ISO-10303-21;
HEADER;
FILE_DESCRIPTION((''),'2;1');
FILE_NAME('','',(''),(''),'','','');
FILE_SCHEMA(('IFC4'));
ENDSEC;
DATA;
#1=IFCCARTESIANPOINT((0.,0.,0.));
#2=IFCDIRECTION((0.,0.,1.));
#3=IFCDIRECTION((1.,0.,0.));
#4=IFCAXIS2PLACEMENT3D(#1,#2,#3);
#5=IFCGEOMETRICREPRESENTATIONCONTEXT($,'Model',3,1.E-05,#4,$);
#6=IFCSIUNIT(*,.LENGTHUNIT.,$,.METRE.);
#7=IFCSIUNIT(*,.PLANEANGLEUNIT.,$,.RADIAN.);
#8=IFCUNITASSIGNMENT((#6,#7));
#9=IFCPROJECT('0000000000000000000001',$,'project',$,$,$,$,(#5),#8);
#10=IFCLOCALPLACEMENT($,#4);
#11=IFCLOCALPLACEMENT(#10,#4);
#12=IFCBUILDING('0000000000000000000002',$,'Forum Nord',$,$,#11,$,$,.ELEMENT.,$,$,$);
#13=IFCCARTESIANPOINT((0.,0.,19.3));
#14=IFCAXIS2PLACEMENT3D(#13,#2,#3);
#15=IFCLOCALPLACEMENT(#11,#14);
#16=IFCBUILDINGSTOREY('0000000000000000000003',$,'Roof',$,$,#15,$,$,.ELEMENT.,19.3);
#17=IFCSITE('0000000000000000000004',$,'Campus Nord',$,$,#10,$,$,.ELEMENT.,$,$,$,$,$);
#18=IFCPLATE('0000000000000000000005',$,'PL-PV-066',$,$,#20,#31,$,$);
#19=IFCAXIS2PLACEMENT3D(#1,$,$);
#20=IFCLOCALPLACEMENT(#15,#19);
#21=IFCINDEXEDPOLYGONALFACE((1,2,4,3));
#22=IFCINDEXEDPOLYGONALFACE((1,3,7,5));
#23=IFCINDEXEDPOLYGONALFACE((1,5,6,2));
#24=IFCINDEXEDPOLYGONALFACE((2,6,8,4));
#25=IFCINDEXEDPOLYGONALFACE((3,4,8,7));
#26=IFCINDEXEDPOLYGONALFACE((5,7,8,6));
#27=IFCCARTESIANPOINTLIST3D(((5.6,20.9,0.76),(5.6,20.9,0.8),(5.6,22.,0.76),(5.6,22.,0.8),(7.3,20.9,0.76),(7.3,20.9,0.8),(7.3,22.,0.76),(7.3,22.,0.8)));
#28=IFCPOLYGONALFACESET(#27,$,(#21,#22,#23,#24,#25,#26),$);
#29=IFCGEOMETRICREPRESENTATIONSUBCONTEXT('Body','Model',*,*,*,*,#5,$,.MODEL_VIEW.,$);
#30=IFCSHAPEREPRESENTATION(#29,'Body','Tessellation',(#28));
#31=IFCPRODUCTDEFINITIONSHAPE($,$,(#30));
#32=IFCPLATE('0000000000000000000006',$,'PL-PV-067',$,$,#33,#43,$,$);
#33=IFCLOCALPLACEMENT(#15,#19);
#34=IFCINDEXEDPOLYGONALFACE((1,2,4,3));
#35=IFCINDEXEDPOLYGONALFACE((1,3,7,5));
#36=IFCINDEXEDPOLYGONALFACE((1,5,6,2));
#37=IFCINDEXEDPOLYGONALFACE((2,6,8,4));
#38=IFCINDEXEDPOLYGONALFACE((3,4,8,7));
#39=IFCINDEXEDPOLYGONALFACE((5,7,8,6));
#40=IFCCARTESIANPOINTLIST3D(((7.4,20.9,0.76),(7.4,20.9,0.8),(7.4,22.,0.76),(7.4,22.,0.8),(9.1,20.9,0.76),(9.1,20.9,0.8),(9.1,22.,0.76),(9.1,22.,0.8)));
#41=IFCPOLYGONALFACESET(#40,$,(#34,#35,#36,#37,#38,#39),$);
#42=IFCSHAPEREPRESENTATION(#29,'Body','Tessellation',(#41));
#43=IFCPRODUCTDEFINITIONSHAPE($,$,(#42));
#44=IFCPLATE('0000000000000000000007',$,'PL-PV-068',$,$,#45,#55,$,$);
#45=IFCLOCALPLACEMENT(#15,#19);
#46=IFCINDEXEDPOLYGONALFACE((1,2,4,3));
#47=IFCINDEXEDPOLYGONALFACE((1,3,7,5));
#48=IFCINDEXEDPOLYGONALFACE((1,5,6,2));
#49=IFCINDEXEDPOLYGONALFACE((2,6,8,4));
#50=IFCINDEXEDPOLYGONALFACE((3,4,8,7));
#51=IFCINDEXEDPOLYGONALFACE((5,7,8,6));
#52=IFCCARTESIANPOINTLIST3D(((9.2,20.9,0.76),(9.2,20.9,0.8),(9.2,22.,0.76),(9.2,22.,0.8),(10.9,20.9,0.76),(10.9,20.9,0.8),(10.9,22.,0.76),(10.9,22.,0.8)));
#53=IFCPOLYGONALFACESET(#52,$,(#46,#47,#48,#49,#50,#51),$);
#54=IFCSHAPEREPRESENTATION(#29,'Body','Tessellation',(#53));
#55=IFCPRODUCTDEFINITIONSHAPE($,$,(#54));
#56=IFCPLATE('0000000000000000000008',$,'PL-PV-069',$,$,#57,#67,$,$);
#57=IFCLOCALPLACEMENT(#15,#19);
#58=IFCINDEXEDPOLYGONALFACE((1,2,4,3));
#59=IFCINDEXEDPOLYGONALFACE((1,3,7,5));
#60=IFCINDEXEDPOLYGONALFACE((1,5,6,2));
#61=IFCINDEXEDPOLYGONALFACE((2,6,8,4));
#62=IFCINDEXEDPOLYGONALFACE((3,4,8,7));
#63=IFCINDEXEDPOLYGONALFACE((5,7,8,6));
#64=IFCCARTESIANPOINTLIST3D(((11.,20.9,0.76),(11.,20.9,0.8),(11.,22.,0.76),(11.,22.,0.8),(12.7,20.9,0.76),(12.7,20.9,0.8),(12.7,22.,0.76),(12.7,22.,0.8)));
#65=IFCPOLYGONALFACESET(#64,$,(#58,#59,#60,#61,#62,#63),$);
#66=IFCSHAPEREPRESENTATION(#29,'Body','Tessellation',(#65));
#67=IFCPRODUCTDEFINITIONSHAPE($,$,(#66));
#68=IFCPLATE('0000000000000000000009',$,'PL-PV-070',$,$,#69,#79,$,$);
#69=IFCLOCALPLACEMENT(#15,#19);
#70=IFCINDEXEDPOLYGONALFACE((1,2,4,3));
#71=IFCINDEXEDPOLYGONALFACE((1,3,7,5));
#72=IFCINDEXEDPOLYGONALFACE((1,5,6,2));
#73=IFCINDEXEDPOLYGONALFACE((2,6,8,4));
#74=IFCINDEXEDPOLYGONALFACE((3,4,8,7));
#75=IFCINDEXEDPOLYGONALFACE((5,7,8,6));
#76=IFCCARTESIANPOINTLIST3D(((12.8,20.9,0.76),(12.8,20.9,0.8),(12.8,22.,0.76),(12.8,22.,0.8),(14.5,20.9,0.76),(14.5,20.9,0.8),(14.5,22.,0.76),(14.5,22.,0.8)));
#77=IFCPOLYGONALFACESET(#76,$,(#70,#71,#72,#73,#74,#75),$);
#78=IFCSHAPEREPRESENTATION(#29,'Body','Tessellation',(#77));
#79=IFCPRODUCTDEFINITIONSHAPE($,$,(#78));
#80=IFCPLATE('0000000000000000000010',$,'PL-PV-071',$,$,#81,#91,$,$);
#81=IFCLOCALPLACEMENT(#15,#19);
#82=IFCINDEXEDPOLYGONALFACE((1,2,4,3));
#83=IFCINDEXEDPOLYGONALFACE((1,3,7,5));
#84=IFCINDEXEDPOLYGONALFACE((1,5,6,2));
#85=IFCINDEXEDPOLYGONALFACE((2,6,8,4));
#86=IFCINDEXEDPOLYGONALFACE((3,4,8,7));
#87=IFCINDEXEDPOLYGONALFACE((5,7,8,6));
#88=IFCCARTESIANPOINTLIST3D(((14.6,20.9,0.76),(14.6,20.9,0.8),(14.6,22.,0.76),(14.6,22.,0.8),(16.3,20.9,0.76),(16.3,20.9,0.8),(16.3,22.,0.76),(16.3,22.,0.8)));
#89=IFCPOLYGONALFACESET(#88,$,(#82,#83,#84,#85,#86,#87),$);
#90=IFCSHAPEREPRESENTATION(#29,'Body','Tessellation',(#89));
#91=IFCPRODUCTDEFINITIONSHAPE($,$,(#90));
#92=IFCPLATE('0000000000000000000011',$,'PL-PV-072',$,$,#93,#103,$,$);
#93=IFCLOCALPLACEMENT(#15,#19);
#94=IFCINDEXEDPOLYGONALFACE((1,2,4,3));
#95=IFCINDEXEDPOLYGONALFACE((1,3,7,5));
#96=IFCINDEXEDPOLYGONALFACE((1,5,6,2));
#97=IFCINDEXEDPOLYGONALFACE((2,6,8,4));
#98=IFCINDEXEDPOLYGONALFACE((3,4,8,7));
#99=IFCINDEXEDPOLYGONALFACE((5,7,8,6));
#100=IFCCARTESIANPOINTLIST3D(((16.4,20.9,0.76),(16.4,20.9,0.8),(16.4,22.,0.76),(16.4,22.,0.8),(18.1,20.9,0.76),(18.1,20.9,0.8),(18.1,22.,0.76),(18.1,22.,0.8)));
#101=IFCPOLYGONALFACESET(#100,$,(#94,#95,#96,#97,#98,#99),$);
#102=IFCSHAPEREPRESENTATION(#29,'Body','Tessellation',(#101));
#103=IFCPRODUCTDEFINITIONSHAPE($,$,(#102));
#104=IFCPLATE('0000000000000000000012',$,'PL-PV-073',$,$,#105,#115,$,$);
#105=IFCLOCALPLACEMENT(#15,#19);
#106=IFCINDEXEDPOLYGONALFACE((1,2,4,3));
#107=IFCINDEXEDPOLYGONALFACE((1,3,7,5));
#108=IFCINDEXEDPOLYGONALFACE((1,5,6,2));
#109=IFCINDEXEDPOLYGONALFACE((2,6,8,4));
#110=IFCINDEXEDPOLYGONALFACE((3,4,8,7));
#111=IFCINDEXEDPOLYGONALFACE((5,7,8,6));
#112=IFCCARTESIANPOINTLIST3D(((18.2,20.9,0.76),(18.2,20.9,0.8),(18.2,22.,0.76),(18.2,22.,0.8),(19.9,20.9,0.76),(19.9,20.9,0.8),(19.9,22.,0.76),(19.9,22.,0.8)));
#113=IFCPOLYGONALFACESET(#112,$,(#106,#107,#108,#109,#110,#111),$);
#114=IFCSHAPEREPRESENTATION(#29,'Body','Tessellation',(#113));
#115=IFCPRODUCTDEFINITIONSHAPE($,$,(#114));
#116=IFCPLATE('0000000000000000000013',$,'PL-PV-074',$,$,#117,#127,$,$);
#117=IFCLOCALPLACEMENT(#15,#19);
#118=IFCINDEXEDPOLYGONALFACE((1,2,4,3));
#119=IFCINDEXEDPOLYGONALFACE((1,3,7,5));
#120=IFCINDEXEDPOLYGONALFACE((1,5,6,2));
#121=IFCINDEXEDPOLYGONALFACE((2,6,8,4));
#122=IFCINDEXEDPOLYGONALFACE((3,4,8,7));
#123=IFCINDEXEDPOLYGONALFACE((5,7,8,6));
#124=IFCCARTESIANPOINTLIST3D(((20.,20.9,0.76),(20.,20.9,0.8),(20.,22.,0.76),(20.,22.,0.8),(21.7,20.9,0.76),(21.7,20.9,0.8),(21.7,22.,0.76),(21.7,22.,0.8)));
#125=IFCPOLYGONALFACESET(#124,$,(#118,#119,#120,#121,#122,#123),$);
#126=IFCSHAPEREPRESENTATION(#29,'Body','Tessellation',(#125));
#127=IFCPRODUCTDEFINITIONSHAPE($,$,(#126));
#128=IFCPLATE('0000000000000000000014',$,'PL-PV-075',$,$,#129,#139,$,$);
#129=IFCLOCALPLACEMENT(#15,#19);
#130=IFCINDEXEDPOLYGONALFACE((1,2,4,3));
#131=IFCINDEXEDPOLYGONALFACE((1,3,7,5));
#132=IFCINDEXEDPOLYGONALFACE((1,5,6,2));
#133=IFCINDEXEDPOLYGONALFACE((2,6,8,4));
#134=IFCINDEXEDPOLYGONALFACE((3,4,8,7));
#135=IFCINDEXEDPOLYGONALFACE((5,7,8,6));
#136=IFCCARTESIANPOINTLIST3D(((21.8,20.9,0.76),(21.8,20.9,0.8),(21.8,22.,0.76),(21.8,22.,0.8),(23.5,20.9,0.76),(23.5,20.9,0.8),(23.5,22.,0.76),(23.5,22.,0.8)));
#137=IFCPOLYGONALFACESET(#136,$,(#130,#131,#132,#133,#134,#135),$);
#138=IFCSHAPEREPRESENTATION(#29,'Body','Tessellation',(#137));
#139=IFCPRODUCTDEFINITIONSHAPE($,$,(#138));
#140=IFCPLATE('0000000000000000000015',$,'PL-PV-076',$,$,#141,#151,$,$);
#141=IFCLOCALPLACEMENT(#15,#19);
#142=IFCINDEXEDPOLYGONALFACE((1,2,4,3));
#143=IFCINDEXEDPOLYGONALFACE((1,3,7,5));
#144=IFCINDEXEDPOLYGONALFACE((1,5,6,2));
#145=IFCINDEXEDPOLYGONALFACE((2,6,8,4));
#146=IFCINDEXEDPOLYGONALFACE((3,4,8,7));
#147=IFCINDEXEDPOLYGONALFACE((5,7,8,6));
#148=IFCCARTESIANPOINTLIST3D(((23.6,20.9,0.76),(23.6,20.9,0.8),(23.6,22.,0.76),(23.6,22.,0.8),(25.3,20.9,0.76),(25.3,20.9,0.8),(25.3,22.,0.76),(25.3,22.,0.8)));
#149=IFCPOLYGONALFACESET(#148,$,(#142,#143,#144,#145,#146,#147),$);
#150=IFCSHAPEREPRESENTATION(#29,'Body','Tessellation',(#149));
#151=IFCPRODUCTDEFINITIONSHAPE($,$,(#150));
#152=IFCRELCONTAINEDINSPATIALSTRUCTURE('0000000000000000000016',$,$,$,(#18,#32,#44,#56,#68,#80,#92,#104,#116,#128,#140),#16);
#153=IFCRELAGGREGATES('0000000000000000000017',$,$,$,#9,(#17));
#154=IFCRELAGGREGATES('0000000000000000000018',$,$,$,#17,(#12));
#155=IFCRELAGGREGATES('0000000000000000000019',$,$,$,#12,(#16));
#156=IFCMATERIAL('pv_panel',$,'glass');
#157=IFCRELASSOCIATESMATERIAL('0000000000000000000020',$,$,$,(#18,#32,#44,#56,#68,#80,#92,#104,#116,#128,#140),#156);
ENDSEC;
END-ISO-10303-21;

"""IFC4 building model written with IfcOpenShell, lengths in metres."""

from ifc_helpers import new_model, si_unit, frame, origin_with_axes, place, context, subcontext, project, spatial, polyline, outline, extrude, material, element, save


model = new_model("IFC4")

# Units and contexts
model_context = context("Model", 3, precision=1e-05, world=origin_with_axes())
body_context = subcontext(model_context, "Body", "Model", "MODEL_VIEW")
ifc_project = project(units=[si_unit("LENGTHUNIT", "METRE"), si_unit("PLANEANGLEUNIT", "RADIAN")], contexts=[model_context])

# Site, building, storey
site_placement = place(None, origin_with_axes())
site = spatial("IfcSite", under=ifc_project, at=site_placement, Name="Campus Nord", CompositionType="ELEMENT")
building_placement = place(site_placement, origin_with_axes())
building = spatial("IfcBuilding", under=site, at=building_placement, Name="Forum Nord", CompositionType="ELEMENT")
storey_placement = place(building_placement, frame((0.0, 0.0, 19.3), z_axis=(0.0, 0.0, 1.0), x_axis=(1.0, 0.0, 0.0)))
storey = spatial("IfcBuildingStorey", under=building, at=storey_placement, Name="Roof", CompositionType="ELEMENT", Elevation=19.3)

# Plates
ifc_material = material(Name="pv_panel", Category="glass")
plate_1_placement = place(storey_placement, frame((0.0, 0.0, 0.8), z_axis=(0.0, 0.0, 1.0), x_axis=(1.0, 0.0, 0.0)))
element("IfcPlate", 1, at=plate_1_placement, inside=storey, material=ifc_material, Name="PL-PV-066", context=body_context, shape_type="SweptSolid", body=[
    extrude(outline(polyline([(5.6, 20.9), (7.3, 20.9), (7.3, 22.0), (5.6, 22.0), (5.6, 20.9)])), frame((0.0, 0.0, -0.04), z_axis=(0.0, 0.0, 1.0), x_axis=(1.0, 0.0, 0.0)), (0.0, 0.0, 1.0), 0.04),
])
plate_2_placement = place(storey_placement, frame((0.0, 0.0, 0.8), z_axis=(0.0, 0.0, 1.0), x_axis=(1.0, 0.0, 0.0)))
element("IfcPlate", 2, at=plate_2_placement, inside=storey, material=ifc_material, Name="PL-PV-067", context=body_context, shape_type="SweptSolid", body=[
    extrude(outline(polyline([(7.4, 20.9), (9.1, 20.9), (9.1, 22.0), (7.4, 22.0), (7.4, 20.9)])), frame((0.0, 0.0, -0.04), z_axis=(0.0, 0.0, 1.0), x_axis=(1.0, 0.0, 0.0)), (0.0, 0.0, 1.0), 0.04),
])
plate_3_placement = place(storey_placement, frame((0.0, 0.0, 0.8), z_axis=(0.0, 0.0, 1.0), x_axis=(1.0, 0.0, 0.0)))
element("IfcPlate", 3, at=plate_3_placement, inside=storey, material=ifc_material, Name="PL-PV-068", context=body_context, shape_type="SweptSolid", body=[
    extrude(outline(polyline([(9.2, 20.9), (10.9, 20.9), (10.9, 22.0), (9.2, 22.0), (9.2, 20.9)])), frame((0.0, 0.0, -0.04), z_axis=(0.0, 0.0, 1.0), x_axis=(1.0, 0.0, 0.0)), (0.0, 0.0, 1.0), 0.04),
])
plate_4_placement = place(storey_placement, frame((0.0, 0.0, 0.8), z_axis=(0.0, 0.0, 1.0), x_axis=(1.0, 0.0, 0.0)))
element("IfcPlate", 4, at=plate_4_placement, inside=storey, material=ifc_material, Name="PL-PV-069", context=body_context, shape_type="SweptSolid", body=[
    extrude(outline(polyline([(11.0, 20.9), (12.7, 20.9), (12.7, 22.0), (11.0, 22.0), (11.0, 20.9)])), frame((0.0, 0.0, -0.04), z_axis=(0.0, 0.0, 1.0), x_axis=(1.0, 0.0, 0.0)), (0.0, 0.0, 1.0), 0.04),
])
plate_5_placement = place(storey_placement, frame((0.0, 0.0, 0.8), z_axis=(0.0, 0.0, 1.0), x_axis=(1.0, 0.0, 0.0)))
element("IfcPlate", 5, at=plate_5_placement, inside=storey, material=ifc_material, Name="PL-PV-070", context=body_context, shape_type="SweptSolid", body=[
    extrude(outline(polyline([(12.8, 20.9), (14.5, 20.9), (14.5, 22.0), (12.8, 22.0), (12.8, 20.9)])), frame((0.0, 0.0, -0.04), z_axis=(0.0, 0.0, 1.0), x_axis=(1.0, 0.0, 0.0)), (0.0, 0.0, 1.0), 0.04),
])
plate_6_placement = place(storey_placement, frame((0.0, 0.0, 0.8), z_axis=(0.0, 0.0, 1.0), x_axis=(1.0, 0.0, 0.0)))
element("IfcPlate", 6, at=plate_6_placement, inside=storey, material=ifc_material, Name="PL-PV-071", context=body_context, shape_type="SweptSolid", body=[
    extrude(outline(polyline([(14.6, 20.9), (16.3, 20.9), (16.3, 22.0), (14.6, 22.0), (14.6, 20.9)])), frame((0.0, 0.0, -0.04), z_axis=(0.0, 0.0, 1.0), x_axis=(1.0, 0.0, 0.0)), (0.0, 0.0, 1.0), 0.04),
])
plate_7_placement = place(storey_placement, frame((0.0, 0.0, 0.8), z_axis=(0.0, 0.0, 1.0), x_axis=(1.0, 0.0, 0.0)))
element("IfcPlate", 7, at=plate_7_placement, inside=storey, material=ifc_material, Name="PL-PV-072", context=body_context, shape_type="SweptSolid", body=[
    extrude(outline(polyline([(16.4, 20.9), (18.1, 20.9), (18.1, 22.0), (16.4, 22.0), (16.4, 20.9)])), frame((0.0, 0.0, -0.04), z_axis=(0.0, 0.0, 1.0), x_axis=(1.0, 0.0, 0.0)), (0.0, 0.0, 1.0), 0.04),
])
plate_8_placement = place(storey_placement, frame((0.0, 0.0, 0.8), z_axis=(0.0, 0.0, 1.0), x_axis=(1.0, 0.0, 0.0)))
element("IfcPlate", 8, at=plate_8_placement, inside=storey, material=ifc_material, Name="PL-PV-073", context=body_context, shape_type="SweptSolid", body=[
    extrude(outline(polyline([(18.2, 20.9), (19.9, 20.9), (19.9, 22.0), (18.2, 22.0), (18.2, 20.9)])), frame((0.0, 0.0, -0.04), z_axis=(0.0, 0.0, 1.0), x_axis=(1.0, 0.0, 0.0)), (0.0, 0.0, 1.0), 0.04),
])
plate_9_placement = place(storey_placement, frame((0.0, 0.0, 0.8), z_axis=(0.0, 0.0, 1.0), x_axis=(1.0, 0.0, 0.0)))
element("IfcPlate", 9, at=plate_9_placement, inside=storey, material=ifc_material, Name="PL-PV-074", context=body_context, shape_type="SweptSolid", body=[
    extrude(outline(polyline([(20.0, 20.9), (21.7, 20.9), (21.7, 22.0), (20.0, 22.0), (20.0, 20.9)])), frame((0.0, 0.0, -0.04), z_axis=(0.0, 0.0, 1.0), x_axis=(1.0, 0.0, 0.0)), (0.0, 0.0, 1.0), 0.04),
])
plate_10_placement = place(storey_placement, frame((0.0, 0.0, 0.8), z_axis=(0.0, 0.0, 1.0), x_axis=(1.0, 0.0, 0.0)))
element("IfcPlate", 10, at=plate_10_placement, inside=storey, material=ifc_material, Name="PL-PV-075", context=body_context, shape_type="SweptSolid", body=[
    extrude(outline(polyline([(21.8, 20.9), (23.5, 20.9), (23.5, 22.0), (21.8, 22.0), (21.8, 20.9)])), frame((0.0, 0.0, -0.04), z_axis=(0.0, 0.0, 1.0), x_axis=(1.0, 0.0, 0.0)), (0.0, 0.0, 1.0), 0.04),
])
plate_11_placement = place(storey_placement, frame((0.0, 0.0, 0.8), z_axis=(0.0, 0.0, 1.0), x_axis=(1.0, 0.0, 0.0)))
element("IfcPlate", 11, at=plate_11_placement, inside=storey, material=ifc_material, Name="PL-PV-076", context=body_context, shape_type="SweptSolid", body=[
    extrude(outline(polyline([(23.6, 20.9), (25.3, 20.9), (25.3, 22.0), (23.6, 22.0), (23.6, 20.9)])), frame((0.0, 0.0, -0.04), z_axis=(0.0, 0.0, 1.0), x_axis=(1.0, 0.0, 0.0)), (0.0, 0.0, 1.0), 0.04),
])

save(model, "model.ifc")
